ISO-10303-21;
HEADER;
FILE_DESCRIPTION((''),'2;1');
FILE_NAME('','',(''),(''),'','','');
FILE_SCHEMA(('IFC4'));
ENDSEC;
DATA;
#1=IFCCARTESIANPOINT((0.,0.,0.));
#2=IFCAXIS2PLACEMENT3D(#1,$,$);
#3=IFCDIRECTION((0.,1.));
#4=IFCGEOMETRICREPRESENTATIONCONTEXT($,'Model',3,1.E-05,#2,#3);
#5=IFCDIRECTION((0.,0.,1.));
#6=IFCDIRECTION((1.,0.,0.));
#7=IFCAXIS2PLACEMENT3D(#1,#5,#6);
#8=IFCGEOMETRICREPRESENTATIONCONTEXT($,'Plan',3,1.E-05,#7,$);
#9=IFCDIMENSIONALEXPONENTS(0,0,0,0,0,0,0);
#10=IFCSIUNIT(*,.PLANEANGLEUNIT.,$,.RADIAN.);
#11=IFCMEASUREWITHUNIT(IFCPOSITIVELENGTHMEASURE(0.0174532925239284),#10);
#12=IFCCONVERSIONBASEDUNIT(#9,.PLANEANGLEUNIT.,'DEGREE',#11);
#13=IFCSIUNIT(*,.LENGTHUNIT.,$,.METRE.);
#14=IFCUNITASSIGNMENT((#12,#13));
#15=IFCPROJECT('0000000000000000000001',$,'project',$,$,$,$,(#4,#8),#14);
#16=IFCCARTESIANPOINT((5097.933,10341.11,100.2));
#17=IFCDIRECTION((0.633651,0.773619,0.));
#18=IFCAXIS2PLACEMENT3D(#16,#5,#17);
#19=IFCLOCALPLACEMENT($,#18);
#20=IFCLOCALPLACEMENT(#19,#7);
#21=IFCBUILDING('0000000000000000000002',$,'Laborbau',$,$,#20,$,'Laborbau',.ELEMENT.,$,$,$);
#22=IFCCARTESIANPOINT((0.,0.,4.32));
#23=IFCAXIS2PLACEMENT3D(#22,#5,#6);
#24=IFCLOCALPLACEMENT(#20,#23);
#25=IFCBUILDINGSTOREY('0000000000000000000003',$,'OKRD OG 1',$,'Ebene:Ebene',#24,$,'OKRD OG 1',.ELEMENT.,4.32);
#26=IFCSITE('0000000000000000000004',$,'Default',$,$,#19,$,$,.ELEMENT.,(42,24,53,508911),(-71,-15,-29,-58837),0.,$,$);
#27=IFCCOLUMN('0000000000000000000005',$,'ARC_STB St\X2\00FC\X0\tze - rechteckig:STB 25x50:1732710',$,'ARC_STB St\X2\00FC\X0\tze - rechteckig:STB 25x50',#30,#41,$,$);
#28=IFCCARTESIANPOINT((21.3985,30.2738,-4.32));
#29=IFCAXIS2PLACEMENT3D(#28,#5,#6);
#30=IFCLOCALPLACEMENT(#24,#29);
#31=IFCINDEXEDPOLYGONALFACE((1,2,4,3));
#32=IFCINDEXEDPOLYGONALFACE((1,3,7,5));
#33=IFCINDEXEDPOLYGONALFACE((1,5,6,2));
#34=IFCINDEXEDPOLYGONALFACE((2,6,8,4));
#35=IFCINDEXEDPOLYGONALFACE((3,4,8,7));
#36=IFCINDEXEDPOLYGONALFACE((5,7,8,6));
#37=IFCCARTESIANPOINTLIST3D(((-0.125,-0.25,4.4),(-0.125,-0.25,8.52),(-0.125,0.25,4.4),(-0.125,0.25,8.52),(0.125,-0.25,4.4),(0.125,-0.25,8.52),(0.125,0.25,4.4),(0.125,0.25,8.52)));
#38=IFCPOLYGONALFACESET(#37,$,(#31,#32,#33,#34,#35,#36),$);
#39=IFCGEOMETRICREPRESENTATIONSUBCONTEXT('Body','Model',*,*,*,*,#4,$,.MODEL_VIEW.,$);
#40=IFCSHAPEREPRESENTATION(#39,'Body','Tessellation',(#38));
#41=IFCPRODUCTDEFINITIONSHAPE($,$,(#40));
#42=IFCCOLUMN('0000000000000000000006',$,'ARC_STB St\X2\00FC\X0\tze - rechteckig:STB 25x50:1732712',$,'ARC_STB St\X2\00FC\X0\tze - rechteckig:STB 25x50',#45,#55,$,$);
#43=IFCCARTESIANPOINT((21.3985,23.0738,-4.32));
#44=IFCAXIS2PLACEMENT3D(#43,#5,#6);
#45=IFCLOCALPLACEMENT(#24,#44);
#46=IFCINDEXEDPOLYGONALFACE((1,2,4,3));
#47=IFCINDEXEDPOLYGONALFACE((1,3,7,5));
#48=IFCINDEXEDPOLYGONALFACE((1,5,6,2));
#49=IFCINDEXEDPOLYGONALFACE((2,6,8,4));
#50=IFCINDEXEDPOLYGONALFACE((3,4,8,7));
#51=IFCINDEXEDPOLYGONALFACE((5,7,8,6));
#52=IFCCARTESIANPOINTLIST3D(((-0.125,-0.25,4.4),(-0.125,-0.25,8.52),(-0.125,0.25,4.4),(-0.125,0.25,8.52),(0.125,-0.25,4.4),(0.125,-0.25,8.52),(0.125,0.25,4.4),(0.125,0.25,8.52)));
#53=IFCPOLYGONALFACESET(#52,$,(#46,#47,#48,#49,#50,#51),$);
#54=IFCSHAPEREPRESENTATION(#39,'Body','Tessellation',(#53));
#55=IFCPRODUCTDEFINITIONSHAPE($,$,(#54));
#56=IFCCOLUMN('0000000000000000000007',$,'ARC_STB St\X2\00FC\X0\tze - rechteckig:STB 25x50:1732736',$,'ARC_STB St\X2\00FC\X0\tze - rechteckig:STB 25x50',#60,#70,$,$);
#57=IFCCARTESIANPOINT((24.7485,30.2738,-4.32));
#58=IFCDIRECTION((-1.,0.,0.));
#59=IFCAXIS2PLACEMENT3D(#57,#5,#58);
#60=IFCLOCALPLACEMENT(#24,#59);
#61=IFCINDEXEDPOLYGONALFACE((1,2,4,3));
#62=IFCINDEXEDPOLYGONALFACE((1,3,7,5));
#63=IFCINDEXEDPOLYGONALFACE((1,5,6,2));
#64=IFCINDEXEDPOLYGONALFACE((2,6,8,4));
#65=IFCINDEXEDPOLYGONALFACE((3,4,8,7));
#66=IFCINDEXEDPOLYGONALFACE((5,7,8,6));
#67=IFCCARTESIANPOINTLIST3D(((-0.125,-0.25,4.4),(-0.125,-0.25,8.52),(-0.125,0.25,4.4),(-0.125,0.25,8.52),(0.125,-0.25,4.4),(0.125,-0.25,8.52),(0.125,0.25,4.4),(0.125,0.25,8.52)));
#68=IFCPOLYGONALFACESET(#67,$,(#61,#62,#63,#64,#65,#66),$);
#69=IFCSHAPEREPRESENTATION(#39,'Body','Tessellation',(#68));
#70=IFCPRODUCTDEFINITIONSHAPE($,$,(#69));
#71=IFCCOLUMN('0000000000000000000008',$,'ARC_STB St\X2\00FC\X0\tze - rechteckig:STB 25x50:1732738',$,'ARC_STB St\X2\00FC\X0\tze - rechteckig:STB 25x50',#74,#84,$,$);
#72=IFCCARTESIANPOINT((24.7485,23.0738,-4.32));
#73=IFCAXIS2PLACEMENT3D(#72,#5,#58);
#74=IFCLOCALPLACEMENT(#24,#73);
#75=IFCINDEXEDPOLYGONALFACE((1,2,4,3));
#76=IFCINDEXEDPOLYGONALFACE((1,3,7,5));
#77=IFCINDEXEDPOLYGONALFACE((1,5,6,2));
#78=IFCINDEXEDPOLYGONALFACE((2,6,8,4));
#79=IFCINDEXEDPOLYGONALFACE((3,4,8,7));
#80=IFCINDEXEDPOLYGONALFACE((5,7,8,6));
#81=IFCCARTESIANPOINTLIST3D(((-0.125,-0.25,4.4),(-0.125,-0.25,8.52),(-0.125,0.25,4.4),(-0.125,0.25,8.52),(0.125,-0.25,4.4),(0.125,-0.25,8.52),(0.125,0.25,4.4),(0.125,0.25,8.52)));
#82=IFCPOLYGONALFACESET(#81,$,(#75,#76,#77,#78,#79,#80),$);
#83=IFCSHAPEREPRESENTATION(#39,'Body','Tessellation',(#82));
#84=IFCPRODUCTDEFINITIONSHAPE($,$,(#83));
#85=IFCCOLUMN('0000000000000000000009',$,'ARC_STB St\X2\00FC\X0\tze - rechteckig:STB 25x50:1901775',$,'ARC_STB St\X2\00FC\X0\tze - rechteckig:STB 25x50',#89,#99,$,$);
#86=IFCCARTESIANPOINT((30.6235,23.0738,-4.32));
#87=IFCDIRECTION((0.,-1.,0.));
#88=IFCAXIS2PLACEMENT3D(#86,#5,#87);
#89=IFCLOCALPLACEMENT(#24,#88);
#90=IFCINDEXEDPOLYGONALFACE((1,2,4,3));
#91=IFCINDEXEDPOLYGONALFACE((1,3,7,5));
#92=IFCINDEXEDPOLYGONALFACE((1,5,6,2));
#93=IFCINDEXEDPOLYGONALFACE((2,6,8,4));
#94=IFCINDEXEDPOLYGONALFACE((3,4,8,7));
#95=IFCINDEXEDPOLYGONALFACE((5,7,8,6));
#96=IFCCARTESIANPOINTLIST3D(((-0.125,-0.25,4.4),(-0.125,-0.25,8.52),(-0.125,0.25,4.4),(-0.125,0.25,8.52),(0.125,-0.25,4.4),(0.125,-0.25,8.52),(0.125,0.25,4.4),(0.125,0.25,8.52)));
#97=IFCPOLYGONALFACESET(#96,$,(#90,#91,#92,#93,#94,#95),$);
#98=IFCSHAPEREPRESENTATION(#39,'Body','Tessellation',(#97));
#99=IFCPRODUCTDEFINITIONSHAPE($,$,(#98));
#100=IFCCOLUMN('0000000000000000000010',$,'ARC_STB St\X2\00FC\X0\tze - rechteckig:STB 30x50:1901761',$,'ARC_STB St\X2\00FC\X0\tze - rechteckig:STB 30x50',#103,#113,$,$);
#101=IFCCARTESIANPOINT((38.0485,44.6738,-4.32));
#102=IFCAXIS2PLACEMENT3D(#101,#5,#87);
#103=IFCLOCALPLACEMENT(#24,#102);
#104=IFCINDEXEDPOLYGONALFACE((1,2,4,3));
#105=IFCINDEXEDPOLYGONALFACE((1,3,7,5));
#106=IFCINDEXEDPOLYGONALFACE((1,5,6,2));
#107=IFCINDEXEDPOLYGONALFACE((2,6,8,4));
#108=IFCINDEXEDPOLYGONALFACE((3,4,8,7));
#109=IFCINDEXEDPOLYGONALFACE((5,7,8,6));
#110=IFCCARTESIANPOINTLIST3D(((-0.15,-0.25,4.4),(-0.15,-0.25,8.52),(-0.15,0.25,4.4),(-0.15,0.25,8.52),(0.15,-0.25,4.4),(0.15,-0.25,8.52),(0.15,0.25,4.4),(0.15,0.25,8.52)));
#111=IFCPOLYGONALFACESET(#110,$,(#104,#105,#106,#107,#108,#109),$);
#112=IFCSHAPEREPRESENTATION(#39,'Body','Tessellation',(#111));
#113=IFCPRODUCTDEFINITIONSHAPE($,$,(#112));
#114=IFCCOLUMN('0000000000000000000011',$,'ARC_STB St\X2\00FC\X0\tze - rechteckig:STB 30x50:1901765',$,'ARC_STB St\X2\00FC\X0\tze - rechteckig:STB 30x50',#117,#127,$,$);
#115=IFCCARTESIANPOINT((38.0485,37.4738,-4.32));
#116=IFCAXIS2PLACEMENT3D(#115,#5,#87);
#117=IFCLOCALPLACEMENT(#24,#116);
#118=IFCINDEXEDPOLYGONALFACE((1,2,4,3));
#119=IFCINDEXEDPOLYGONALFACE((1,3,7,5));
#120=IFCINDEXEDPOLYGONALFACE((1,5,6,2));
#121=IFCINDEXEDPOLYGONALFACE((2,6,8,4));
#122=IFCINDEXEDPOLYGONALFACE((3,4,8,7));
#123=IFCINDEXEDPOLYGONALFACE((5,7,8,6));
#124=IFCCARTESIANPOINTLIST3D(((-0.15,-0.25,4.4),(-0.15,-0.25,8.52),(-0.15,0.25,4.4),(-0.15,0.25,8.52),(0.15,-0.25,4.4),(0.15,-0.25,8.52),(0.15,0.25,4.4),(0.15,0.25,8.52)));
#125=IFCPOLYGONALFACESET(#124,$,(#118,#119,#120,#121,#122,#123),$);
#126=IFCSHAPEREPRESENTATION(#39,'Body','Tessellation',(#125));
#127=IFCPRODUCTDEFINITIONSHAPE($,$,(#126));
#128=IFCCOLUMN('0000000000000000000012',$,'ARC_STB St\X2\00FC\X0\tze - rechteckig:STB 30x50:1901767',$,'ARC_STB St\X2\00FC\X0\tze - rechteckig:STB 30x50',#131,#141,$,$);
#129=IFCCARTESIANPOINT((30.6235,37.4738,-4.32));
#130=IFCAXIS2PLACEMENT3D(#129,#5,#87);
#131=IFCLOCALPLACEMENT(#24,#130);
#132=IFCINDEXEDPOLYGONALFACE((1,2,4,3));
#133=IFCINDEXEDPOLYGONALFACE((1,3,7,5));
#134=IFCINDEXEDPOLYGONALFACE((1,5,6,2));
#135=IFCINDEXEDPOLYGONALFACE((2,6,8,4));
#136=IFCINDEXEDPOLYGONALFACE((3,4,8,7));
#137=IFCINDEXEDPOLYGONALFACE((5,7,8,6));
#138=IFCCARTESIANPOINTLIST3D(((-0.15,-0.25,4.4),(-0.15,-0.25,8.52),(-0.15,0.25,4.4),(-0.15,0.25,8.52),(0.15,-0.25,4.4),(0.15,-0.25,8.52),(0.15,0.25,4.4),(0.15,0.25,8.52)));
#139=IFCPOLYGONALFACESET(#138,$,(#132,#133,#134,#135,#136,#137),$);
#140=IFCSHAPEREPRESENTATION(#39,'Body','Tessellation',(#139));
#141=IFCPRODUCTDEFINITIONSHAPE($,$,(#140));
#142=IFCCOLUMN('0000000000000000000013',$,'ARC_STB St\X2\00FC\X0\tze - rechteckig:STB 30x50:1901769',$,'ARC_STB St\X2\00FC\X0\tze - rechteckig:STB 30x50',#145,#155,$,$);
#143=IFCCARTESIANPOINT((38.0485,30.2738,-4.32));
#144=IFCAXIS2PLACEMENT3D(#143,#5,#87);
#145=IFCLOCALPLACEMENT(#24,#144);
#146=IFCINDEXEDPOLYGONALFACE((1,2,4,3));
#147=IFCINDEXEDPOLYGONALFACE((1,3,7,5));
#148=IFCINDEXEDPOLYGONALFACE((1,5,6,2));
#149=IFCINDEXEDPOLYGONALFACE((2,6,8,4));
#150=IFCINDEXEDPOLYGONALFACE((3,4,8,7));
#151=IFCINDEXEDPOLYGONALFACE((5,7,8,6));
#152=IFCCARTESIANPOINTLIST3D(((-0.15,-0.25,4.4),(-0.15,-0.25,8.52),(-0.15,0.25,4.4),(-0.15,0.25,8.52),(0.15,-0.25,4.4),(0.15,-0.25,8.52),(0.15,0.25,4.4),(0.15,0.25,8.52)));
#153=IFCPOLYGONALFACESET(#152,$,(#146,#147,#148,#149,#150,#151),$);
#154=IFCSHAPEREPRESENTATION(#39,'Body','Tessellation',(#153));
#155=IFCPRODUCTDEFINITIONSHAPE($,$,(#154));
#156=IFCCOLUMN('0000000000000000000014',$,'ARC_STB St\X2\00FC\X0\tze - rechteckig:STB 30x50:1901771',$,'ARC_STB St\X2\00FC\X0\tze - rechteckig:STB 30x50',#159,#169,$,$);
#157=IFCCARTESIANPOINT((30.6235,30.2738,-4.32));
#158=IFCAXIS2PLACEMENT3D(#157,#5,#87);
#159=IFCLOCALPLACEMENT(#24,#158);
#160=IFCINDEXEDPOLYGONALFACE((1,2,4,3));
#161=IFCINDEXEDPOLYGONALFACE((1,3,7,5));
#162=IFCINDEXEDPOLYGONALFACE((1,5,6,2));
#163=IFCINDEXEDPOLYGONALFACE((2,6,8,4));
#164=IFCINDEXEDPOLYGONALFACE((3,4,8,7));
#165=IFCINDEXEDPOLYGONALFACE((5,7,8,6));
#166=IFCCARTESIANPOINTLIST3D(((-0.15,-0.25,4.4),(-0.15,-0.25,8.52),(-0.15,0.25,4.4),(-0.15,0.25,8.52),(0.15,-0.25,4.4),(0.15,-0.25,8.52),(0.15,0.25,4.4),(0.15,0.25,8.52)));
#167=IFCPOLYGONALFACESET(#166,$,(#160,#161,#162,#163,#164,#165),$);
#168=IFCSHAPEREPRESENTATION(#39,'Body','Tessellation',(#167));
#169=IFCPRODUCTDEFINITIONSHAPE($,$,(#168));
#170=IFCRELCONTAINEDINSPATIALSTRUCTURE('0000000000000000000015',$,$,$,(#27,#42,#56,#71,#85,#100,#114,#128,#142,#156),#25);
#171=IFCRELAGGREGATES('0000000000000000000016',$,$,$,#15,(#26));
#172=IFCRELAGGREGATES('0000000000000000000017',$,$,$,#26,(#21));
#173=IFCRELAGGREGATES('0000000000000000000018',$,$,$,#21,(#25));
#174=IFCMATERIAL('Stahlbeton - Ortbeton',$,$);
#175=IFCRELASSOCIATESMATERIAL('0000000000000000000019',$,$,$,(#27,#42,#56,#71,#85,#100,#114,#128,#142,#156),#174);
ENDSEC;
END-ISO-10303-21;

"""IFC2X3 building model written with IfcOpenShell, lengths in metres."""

from ifc_helpers import new_model, entity, si_unit, converted_unit, direction, frame, origin, origin_with_axes, origin_2d_with_axis, place, context, subcontext, project, spatial, rectangle, extrude, source, transform, mapped, material, element, save


model = new_model("IFC2X3")

# Units and contexts
model_context = context("Model", 3, precision=1e-05, world=origin(), true_north=direction((0.0, 1.0)))
plan_context = context("Plan", 3, precision=1e-05, world=origin_with_axes())
body_context = subcontext(model_context, "Body", "Model", "MODEL_VIEW")
ifc_project = project(units=[converted_unit("PLANEANGLEUNIT", "DEGREE", entity("IfcPositiveLengthMeasure", 0.0174532925239284), si_unit("PLANEANGLEUNIT", "RADIAN"), dimensions=[0, 0, 0, 0, 0, 0, 0]), si_unit("LENGTHUNIT", "METRE")], contexts=[model_context, plan_context])

# Site, building, storey
site_placement = place(None, frame((5097.933, 10341.11, 100.2), z_axis=(0.0, 0.0, 1.0), x_axis=(0.633651, 0.773619, 0.0)))
site = spatial("IfcSite", under=ifc_project, at=site_placement, Name="Default", CompositionType="ELEMENT", RefLatitude=(42, 24, 53, 508911), RefLongitude=(-71, -15, -29, -58837), RefElevation=0.0)
building_placement = place(site_placement, origin_with_axes())
building = spatial("IfcBuilding", under=site, at=building_placement, Name="Laborbau", LongName="Laborbau", CompositionType="ELEMENT")
storey_placement = place(building_placement, frame((0.0, 0.0, 4.32), z_axis=(0.0, 0.0, 1.0), x_axis=(1.0, 0.0, 0.0)))
storey = spatial("IfcBuildingStorey", under=building, at=storey_placement, Name="OKRD OG 1", ObjectType="Ebene:Ebene", LongName="OKRD OG 1", CompositionType="ELEMENT", Elevation=4.32)

# Columns
ifc_material_1 = material(Name="Stahlbeton - Ortbeton")
shared_shape_1 = source(origin(), body_context, "Body", "SweptSolid", [
    extrude(rectangle(XDim=0.5, YDim=0.25, at=origin_2d_with_axis()), frame((0.0, 0.0, 4.4), z_axis=(0.0, 0.0, 1.0), x_axis=(0.0, -1.0, 0.0)), (0.0, 0.0, 1.0), 4.12),
])
for number, where, z_axis, x_axis, name in (
    (1, (21.3985, 30.2738, -4.32), (0.0, 0.0, 1.0), (1.0, 0.0, 0.0), "ARC_STB Stütze - rechteckig:STB 25x50:1732710"),
    (2, (21.3985, 23.0738, -4.32), (0.0, 0.0, 1.0), (1.0, 0.0, 0.0), "ARC_STB Stütze - rechteckig:STB 25x50:1732712"),
    (3, (24.7485, 30.2738, -4.32), (0.0, 0.0, 1.0), (-1.0, 0.0, 0.0), "ARC_STB Stütze - rechteckig:STB 25x50:1732736"),
    (4, (24.7485, 23.0738, -4.32), (0.0, 0.0, 1.0), (-1.0, 0.0, 0.0), "ARC_STB Stütze - rechteckig:STB 25x50:1732738"),
    (5, (30.6235, 23.0738, -4.32), (0.0, 0.0, 1.0), (0.0, -1.0, 0.0), "ARC_STB Stütze - rechteckig:STB 25x50:1901775"),
):
    element("IfcColumn", number, at=place(storey_placement, frame(where, z_axis=z_axis, x_axis=x_axis)), inside=storey, material=ifc_material_1, Name=name, ObjectType="ARC_STB Stütze - rechteckig:STB 25x50", context=body_context, shape_type="MappedRepresentation", body=[
        mapped(shared_shape_1, transform((0.0, 0.0, 0.0), scale=1.0)),
    ])
shared_shape_2 = source(origin(), body_context, "Body", "SweptSolid", [
    extrude(rectangle(XDim=0.5, YDim=0.3, at=origin_2d_with_axis()), frame((0.0, 0.0, 4.4), z_axis=(0.0, 0.0, 1.0), x_axis=(0.0, -1.0, 0.0)), (0.0, 0.0, 1.0), 4.12),
])
for number, where, z_axis, x_axis, name in (
    (6, (38.0485, 44.6738, -4.32), (0.0, 0.0, 1.0), (0.0, -1.0, 0.0), "ARC_STB Stütze - rechteckig:STB 30x50:1901761"),
    (7, (38.0485, 37.4738, -4.32), (0.0, 0.0, 1.0), (0.0, -1.0, 0.0), "ARC_STB Stütze - rechteckig:STB 30x50:1901765"),
    (8, (30.6235, 37.4738, -4.32), (0.0, 0.0, 1.0), (0.0, -1.0, 0.0), "ARC_STB Stütze - rechteckig:STB 30x50:1901767"),
    (9, (38.0485, 30.2738, -4.32), (0.0, 0.0, 1.0), (0.0, -1.0, 0.0), "ARC_STB Stütze - rechteckig:STB 30x50:1901769"),
    (10, (30.6235, 30.2738, -4.32), (0.0, 0.0, 1.0), (0.0, -1.0, 0.0), "ARC_STB Stütze - rechteckig:STB 30x50:1901771"),
):
    element("IfcColumn", number, at=place(storey_placement, frame(where, z_axis=z_axis, x_axis=x_axis)), inside=storey, material=ifc_material_1, Name=name, ObjectType="ARC_STB Stütze - rechteckig:STB 30x50", context=body_context, shape_type="MappedRepresentation", body=[
        mapped(shared_shape_2, transform((0.0, 0.0, 0.0), scale=1.0)),
    ])

save(model, "model.ifc")
